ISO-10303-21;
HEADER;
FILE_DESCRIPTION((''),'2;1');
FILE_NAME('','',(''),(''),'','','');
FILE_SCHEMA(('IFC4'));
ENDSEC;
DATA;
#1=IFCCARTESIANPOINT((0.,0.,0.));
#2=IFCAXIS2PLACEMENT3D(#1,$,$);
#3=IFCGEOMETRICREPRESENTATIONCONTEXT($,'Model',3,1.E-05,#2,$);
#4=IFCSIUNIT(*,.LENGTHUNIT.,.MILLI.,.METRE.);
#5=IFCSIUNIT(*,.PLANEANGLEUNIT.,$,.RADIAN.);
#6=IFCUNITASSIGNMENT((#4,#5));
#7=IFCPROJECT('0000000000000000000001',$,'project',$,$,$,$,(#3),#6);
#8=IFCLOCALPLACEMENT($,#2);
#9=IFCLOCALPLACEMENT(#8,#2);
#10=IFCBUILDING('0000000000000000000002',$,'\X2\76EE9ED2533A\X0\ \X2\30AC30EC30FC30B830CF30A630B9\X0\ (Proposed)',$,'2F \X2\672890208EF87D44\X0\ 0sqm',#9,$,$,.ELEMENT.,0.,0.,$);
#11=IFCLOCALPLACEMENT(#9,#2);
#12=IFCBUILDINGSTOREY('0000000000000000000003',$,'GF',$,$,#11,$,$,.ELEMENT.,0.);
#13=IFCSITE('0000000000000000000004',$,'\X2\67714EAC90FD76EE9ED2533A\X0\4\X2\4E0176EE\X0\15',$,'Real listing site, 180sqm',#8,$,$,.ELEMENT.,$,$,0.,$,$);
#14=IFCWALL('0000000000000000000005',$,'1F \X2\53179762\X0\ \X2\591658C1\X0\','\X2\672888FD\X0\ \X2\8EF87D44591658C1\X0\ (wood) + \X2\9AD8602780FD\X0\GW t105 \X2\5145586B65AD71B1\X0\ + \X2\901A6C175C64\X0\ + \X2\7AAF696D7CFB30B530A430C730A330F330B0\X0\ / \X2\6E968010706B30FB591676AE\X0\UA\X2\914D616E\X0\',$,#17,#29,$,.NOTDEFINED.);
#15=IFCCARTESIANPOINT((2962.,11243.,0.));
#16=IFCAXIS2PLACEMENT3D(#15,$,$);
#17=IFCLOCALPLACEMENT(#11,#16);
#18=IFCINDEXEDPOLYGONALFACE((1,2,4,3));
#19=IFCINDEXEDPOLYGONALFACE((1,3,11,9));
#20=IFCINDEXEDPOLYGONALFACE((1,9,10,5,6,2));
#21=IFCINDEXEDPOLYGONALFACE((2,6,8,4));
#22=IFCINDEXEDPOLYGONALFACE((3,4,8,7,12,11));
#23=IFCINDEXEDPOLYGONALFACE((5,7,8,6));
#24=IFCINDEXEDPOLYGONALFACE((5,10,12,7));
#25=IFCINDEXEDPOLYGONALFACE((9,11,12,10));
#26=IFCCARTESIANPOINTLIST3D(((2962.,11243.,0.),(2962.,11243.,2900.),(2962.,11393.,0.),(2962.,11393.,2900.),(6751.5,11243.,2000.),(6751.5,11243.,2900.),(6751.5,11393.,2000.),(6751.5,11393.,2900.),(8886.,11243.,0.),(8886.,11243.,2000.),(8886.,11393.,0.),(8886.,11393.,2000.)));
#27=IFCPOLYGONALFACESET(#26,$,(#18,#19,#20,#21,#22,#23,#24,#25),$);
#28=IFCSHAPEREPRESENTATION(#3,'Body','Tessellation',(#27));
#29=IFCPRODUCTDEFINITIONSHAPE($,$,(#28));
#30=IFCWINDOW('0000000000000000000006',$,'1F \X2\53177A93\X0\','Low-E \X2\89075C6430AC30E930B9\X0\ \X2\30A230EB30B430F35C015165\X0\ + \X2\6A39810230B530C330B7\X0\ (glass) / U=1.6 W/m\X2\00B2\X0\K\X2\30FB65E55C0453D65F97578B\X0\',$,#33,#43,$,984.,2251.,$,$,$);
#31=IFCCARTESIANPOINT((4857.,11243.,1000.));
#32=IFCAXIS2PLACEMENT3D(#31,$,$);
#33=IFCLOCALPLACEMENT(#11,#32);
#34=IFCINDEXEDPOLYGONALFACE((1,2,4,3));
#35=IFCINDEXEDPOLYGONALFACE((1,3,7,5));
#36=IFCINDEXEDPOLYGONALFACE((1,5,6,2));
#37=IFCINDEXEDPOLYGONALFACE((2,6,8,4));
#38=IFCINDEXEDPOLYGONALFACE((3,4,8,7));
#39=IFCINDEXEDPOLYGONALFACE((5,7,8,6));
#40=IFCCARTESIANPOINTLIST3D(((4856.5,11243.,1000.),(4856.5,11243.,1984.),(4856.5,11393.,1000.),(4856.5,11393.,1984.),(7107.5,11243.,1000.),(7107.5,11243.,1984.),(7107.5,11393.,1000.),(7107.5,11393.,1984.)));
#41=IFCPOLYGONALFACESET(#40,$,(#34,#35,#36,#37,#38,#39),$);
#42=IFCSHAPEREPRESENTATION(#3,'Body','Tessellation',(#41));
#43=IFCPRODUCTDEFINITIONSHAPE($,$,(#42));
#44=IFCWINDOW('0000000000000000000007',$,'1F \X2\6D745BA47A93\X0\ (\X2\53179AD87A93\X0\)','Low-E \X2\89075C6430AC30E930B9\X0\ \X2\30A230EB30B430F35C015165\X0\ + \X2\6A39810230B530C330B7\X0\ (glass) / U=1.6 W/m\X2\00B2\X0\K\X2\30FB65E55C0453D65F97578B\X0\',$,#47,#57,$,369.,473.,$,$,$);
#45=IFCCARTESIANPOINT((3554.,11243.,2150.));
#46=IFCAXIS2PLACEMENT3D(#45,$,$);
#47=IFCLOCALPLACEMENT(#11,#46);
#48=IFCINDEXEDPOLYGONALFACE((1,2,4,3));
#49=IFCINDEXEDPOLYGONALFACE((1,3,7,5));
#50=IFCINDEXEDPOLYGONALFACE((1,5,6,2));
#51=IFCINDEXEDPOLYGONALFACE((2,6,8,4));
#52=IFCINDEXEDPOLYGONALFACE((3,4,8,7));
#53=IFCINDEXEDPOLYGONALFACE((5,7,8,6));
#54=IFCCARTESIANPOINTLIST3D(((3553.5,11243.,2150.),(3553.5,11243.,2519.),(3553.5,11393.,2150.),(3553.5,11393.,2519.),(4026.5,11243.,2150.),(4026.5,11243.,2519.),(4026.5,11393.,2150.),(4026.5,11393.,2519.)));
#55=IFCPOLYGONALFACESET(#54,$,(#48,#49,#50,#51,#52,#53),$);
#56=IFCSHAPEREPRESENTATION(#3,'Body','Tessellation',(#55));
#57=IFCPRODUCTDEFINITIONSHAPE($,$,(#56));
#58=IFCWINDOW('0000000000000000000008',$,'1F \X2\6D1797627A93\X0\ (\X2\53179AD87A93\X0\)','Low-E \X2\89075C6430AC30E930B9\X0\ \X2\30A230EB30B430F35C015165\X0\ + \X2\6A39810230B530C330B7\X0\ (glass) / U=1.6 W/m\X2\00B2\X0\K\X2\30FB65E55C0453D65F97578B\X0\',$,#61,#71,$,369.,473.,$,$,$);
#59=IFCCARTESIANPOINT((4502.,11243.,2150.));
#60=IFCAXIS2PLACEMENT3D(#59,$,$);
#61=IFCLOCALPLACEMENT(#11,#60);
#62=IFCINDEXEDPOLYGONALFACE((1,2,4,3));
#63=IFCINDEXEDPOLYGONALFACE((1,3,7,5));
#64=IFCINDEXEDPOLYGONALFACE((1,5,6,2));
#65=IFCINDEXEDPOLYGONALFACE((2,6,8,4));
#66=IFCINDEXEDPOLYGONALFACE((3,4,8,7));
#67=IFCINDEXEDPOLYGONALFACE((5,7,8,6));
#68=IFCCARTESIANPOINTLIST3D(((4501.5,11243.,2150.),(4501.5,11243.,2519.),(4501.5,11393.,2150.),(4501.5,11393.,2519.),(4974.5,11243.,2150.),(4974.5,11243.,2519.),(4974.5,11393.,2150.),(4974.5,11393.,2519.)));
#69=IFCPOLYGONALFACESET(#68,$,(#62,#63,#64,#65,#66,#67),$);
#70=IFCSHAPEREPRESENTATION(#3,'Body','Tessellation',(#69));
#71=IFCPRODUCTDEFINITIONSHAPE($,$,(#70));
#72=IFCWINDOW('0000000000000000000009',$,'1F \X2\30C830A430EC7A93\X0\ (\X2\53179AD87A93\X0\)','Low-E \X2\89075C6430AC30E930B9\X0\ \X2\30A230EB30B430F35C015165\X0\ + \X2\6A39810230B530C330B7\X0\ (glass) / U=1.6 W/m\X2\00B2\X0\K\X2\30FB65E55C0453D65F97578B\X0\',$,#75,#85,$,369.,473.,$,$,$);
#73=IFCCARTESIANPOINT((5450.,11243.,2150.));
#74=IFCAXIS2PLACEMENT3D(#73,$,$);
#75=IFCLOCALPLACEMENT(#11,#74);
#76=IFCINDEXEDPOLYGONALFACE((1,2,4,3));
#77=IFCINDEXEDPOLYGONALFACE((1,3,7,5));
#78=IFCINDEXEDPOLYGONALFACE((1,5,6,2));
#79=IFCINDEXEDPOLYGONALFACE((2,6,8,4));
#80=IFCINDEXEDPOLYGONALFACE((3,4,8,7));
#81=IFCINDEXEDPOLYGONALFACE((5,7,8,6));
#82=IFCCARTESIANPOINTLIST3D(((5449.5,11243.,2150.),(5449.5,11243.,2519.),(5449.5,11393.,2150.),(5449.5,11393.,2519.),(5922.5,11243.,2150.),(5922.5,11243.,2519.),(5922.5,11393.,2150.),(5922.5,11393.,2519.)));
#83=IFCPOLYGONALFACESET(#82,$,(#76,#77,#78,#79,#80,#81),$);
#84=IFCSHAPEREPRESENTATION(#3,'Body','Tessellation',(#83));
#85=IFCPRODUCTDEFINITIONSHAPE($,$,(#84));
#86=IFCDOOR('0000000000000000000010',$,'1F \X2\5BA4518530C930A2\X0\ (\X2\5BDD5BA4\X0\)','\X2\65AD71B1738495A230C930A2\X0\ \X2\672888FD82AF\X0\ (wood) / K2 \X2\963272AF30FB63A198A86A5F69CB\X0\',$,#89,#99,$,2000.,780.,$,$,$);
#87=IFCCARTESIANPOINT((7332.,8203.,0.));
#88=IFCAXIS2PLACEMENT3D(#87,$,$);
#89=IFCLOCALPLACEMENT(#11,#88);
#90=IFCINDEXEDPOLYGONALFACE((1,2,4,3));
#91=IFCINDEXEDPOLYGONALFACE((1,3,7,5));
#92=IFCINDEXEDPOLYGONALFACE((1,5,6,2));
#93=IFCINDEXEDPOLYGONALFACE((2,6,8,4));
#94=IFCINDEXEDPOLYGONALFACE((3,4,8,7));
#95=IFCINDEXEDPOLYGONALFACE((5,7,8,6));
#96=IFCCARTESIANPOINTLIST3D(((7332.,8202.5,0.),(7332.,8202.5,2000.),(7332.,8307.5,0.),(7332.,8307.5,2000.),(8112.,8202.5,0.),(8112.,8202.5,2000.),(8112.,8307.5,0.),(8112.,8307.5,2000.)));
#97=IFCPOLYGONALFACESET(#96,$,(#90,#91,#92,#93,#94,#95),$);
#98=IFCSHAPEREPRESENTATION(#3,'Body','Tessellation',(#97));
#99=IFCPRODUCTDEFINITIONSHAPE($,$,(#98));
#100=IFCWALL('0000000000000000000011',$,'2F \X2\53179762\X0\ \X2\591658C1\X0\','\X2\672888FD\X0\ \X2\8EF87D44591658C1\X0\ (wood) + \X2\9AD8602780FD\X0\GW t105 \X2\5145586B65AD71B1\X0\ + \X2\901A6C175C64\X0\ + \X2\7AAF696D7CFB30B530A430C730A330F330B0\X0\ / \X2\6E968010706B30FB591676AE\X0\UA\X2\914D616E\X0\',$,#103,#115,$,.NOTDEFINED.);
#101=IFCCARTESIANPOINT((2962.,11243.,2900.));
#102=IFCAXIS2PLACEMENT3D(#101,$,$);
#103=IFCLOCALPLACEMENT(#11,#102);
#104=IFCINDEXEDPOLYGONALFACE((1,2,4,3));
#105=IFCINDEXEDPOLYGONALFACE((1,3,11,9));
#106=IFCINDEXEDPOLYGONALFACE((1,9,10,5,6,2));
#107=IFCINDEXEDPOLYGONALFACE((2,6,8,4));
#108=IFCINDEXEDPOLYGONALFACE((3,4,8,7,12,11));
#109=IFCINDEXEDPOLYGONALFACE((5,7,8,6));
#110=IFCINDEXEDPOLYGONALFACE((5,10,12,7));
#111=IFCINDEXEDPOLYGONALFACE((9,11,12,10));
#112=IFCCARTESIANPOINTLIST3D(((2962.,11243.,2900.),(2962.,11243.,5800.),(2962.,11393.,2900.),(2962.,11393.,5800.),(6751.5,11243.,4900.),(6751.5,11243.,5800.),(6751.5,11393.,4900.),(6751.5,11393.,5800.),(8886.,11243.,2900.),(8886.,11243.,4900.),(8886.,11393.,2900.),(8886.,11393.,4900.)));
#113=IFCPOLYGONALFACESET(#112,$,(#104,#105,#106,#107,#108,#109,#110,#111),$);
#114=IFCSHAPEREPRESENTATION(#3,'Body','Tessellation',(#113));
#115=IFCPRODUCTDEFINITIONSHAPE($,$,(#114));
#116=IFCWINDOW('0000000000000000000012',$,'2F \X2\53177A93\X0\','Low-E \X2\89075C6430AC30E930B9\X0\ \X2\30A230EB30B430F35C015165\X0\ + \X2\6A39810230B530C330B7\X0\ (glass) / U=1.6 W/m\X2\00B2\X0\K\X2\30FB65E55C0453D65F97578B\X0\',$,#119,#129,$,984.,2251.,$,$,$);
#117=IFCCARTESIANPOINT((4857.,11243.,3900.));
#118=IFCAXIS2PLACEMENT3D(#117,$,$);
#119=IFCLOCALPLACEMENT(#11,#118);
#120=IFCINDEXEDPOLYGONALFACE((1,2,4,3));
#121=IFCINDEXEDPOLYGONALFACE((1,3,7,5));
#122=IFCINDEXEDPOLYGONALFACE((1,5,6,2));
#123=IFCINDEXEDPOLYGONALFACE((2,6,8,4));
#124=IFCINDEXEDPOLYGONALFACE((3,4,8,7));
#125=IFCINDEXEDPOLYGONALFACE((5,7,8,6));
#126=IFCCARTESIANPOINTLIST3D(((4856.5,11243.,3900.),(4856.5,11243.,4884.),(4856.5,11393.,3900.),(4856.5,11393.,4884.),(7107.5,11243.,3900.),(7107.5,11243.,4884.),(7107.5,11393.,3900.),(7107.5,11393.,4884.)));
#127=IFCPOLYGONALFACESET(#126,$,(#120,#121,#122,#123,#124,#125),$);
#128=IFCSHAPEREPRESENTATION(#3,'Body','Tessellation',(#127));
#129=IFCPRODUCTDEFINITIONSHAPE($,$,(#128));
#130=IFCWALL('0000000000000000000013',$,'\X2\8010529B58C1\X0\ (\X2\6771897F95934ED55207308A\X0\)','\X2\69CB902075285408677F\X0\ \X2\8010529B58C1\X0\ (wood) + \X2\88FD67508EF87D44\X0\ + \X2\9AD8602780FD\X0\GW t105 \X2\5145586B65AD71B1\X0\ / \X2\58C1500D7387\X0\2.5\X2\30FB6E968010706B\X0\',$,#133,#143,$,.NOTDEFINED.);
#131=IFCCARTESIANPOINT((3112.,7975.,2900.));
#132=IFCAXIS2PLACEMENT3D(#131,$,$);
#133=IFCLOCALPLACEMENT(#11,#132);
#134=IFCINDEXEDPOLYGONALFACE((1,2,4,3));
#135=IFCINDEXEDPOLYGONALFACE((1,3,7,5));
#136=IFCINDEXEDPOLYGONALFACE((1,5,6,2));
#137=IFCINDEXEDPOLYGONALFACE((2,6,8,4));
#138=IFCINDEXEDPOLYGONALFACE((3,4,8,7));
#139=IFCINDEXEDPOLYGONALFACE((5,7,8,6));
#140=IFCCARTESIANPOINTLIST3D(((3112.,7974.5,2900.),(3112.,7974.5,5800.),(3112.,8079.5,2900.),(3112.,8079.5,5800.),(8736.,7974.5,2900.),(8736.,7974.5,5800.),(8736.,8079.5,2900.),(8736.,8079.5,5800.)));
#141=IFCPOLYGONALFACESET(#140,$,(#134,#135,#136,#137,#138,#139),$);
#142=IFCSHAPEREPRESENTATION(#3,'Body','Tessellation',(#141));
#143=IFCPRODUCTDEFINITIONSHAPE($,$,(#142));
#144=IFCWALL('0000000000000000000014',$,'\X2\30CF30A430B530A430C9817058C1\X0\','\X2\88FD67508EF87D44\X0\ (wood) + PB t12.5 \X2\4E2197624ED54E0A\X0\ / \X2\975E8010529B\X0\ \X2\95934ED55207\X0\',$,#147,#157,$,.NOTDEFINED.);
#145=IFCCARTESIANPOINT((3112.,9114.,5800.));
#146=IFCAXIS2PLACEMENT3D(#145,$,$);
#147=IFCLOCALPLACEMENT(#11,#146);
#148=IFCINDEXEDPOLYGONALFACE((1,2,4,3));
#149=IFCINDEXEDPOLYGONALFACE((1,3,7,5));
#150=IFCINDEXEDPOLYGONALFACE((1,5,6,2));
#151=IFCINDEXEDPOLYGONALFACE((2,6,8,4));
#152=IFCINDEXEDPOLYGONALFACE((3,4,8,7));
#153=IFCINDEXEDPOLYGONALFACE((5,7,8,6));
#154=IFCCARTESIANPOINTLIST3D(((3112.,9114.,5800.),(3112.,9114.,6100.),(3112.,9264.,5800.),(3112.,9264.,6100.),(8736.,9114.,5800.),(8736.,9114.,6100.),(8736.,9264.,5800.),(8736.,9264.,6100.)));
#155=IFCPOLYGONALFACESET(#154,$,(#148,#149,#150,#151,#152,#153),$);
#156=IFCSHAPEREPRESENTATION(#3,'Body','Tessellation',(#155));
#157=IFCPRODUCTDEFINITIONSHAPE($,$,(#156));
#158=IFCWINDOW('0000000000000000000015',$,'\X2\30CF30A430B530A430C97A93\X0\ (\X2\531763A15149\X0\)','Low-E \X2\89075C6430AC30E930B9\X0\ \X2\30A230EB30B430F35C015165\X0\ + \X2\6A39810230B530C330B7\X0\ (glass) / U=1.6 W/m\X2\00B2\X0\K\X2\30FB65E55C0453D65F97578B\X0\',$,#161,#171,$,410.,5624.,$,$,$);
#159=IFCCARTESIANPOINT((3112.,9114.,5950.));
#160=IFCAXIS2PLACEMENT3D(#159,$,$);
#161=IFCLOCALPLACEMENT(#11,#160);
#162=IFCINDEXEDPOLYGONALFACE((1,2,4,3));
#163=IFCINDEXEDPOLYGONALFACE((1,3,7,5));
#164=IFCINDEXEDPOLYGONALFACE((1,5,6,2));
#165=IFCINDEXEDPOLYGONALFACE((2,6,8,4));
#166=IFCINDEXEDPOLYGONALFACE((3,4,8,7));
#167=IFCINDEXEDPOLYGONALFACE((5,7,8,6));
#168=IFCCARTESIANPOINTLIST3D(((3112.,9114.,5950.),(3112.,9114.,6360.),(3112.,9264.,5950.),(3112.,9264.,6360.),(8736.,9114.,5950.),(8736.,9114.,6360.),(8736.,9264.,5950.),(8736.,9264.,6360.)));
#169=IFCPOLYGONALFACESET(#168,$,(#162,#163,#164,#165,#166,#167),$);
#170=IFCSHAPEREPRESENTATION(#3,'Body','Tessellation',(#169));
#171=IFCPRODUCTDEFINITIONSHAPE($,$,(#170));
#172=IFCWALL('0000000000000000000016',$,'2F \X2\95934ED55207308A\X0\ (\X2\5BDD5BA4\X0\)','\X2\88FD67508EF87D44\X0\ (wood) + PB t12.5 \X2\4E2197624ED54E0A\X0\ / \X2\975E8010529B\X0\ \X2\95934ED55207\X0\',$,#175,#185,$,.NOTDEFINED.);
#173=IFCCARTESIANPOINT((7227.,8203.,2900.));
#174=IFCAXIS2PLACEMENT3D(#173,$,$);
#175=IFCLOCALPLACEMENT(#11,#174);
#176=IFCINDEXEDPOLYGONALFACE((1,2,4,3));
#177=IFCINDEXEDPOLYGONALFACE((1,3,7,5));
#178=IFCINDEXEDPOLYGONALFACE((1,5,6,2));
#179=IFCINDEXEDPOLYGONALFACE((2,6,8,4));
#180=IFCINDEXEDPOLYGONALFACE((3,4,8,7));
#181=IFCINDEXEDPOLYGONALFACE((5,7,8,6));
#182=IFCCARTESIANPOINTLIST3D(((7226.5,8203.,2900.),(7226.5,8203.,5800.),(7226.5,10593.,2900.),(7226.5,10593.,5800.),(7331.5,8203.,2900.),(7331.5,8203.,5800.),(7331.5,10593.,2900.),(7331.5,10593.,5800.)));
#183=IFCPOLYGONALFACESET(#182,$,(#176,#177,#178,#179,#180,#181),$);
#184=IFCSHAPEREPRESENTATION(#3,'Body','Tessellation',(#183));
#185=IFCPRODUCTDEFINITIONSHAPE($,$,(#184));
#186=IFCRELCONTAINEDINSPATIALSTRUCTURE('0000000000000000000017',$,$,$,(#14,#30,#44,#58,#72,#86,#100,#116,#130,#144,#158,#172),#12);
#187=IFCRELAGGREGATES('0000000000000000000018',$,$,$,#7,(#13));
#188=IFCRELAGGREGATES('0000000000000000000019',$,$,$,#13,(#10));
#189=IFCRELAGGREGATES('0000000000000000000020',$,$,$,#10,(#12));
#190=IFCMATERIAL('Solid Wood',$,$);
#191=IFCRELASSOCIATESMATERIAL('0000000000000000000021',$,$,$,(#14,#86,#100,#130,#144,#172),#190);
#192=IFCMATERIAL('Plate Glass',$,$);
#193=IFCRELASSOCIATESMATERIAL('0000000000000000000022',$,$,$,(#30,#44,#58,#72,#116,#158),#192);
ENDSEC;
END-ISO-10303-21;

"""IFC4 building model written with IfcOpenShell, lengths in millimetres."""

from ifc_helpers import new_model, si_unit, frame, frame_2d, origin, place, context, project, spatial, rectangle, extrude, material, element, fill, save


model = new_model("IFC4")

# Units and contexts
model_context = context("Model", 3, precision=1e-05, world=origin())
ifc_project = project(units=[si_unit("LENGTHUNIT", "METRE", prefix="MILLI"), si_unit("PLANEANGLEUNIT", "RADIAN")], contexts=[model_context])

# Site, building, storey
site_placement = place(None, origin())
site = spatial("IfcSite", under=ifc_project, at=site_placement, Name="東京都目黒区4丁目15", ObjectType="Real listing site, 180sqm", CompositionType="ELEMENT", RefElevation=0.0)
building_placement = place(site_placement, origin())
building = spatial("IfcBuilding", under=site, at=building_placement, Name="目黒区 ガレージハウス (Proposed)", ObjectType="2F 木造軸組 0sqm", CompositionType="ELEMENT", ElevationOfRefHeight=0.0, ElevationOfTerrain=0.0)
storey_placement = place(building_placement, origin())
storey = spatial("IfcBuildingStorey", under=building, at=storey_placement, Name="GF", CompositionType="ELEMENT", Elevation=0.0)

# Wall, openings, windows
ifc_material_1 = material(Name="Solid Wood")
wall_1_placement = place(storey_placement, frame((2962.0, 11243.0, 0.0)))
wall_1 = element("IfcWall", 1, at=wall_1_placement, inside=storey, material=ifc_material_1, Name="1F 北面 外壁", Description="木製 軸組外壁 (wood) + 高性能GW t105 充填断熱 + 通気層 + 窯業系サイディング / 準耐火・外皮UA配慮", PredefinedType="NOTDEFINED", context=model_context, shape_type="SweptSolid", body=[
    extrude(rectangle(XDim=5924.0, YDim=150.0, at=frame_2d((2962.0, 75.0))), frame((2962.0, 11243.0, 0.0)), (0.0, 0.0, 1.0), 2900.0),
])
opening_1_placement = place(storey_placement, frame((4857.0, 11243.0, 1000.0)))
opening_1 = element("IfcOpeningElement", 2, at=opening_1_placement, cuts=wall_1, PredefinedType="NOTDEFINED", context=model_context, shape_type="SweptSolid", body=[
    extrude(rectangle(XDim=2251.0, YDim=150.0, at=frame_2d((1125.0, 75.0))), frame((4857.0, 11243.0, 1000.0)), (0.0, 0.0, 1.0), 984.0),
])
opening_2_placement = place(storey_placement, frame((3554.0, 11243.0, 2150.0)))
opening_2 = element("IfcOpeningElement", 3, at=opening_2_placement, cuts=wall_1, PredefinedType="NOTDEFINED", context=model_context, shape_type="SweptSolid", body=[
    extrude(rectangle(XDim=473.0, YDim=150.0, at=frame_2d((236.0, 75.0))), frame((3554.0, 11243.0, 2150.0)), (0.0, 0.0, 1.0), 369.0),
])
opening_3_placement = place(storey_placement, frame((4502.0, 11243.0, 2150.0)))
opening_3 = element("IfcOpeningElement", 4, at=opening_3_placement, cuts=wall_1, PredefinedType="NOTDEFINED", context=model_context, shape_type="SweptSolid", body=[
    extrude(rectangle(XDim=473.0, YDim=150.0, at=frame_2d((236.0, 75.0))), frame((4502.0, 11243.0, 2150.0)), (0.0, 0.0, 1.0), 369.0),
])
opening_4_placement = place(storey_placement, frame((5450.0, 11243.0, 2150.0)))
opening_4 = element("IfcOpeningElement", 5, at=opening_4_placement, cuts=wall_1, PredefinedType="NOTDEFINED", context=model_context, shape_type="SweptSolid", body=[
    extrude(rectangle(XDim=473.0, YDim=150.0, at=frame_2d((236.0, 75.0))), frame((5450.0, 11243.0, 2150.0)), (0.0, 0.0, 1.0), 369.0),
])
ifc_material_2 = material(Name="Plate Glass")
window_1_placement = place(storey_placement, frame((4857.0, 11243.0, 1000.0)))
window_1 = element("IfcWindow", 6, at=window_1_placement, inside=storey, material=ifc_material_2, Name="1F 北窓", Description="Low-E 複層ガラス アルゴン封入 + 樹脂サッシ (glass) / U=1.6 W/m²K・日射取得型", OverallHeight=984.0, OverallWidth=2251.0, context=model_context, shape_type="SweptSolid", body=[
    extrude(rectangle(XDim=2251.0, YDim=150.0, at=frame_2d((1125.0, 75.0))), frame((4857.0, 11243.0, 1000.0)), (0.0, 0.0, 1.0), 984.0),
])
fill(opening_1, window_1)
window_2_placement = place(storey_placement, frame((3554.0, 11243.0, 2150.0)))
window_2 = element("IfcWindow", 7, at=window_2_placement, inside=storey, material=ifc_material_2, Name="1F 浴室窓 (北高窓)", Description="Low-E 複層ガラス アルゴン封入 + 樹脂サッシ (glass) / U=1.6 W/m²K・日射取得型", OverallHeight=369.0, OverallWidth=473.0, context=model_context, shape_type="SweptSolid", body=[
    extrude(rectangle(XDim=473.0, YDim=150.0, at=frame_2d((236.0, 75.0))), frame((3554.0, 11243.0, 2150.0)), (0.0, 0.0, 1.0), 369.0),
])
fill(opening_2, window_2)
window_3_placement = place(storey_placement, frame((4502.0, 11243.0, 2150.0)))
window_3 = element("IfcWindow", 8, at=window_3_placement, inside=storey, material=ifc_material_2, Name="1F 洗面窓 (北高窓)", Description="Low-E 複層ガラス アルゴン封入 + 樹脂サッシ (glass) / U=1.6 W/m²K・日射取得型", OverallHeight=369.0, OverallWidth=473.0, context=model_context, shape_type="SweptSolid", body=[
    extrude(rectangle(XDim=473.0, YDim=150.0, at=frame_2d((236.0, 75.0))), frame((4502.0, 11243.0, 2150.0)), (0.0, 0.0, 1.0), 369.0),
])
fill(opening_3, window_3)
window_4_placement = place(storey_placement, frame((5450.0, 11243.0, 2150.0)))
window_4 = element("IfcWindow", 9, at=window_4_placement, inside=storey, material=ifc_material_2, Name="1F トイレ窓 (北高窓)", Description="Low-E 複層ガラス アルゴン封入 + 樹脂サッシ (glass) / U=1.6 W/m²K・日射取得型", OverallHeight=369.0, OverallWidth=473.0, context=model_context, shape_type="SweptSolid", body=[
    extrude(rectangle(XDim=473.0, YDim=150.0, at=frame_2d((236.0, 75.0))), frame((5450.0, 11243.0, 2150.0)), (0.0, 0.0, 1.0), 369.0),
])
fill(opening_4, window_4)

# Door
door_1_placement = place(storey_placement, frame((7332.0, 8203.0, 0.0)))
element("IfcDoor", 10, at=door_1_placement, inside=storey, material=ifc_material_1, Name="1F 室内ドア (寝室)", Description="断熱玄関ドア 木製芯 (wood) / K2 防犯・採風機構", OverallHeight=2000.0, OverallWidth=780.0, context=model_context, shape_type="SweptSolid", body=[
    extrude(rectangle(XDim=780.0, YDim=105.0, at=frame_2d((390.0, 52.0))), frame((7332.0, 8203.0, 0.0)), (0.0, 0.0, 1.0), 2000.0),
])

# Wall, opening, window
wall_2_placement = place(storey_placement, frame((2962.0, 11243.0, 2900.0)))
wall_2 = element("IfcWall", 11, at=wall_2_placement, inside=storey, material=ifc_material_1, Name="2F 北面 外壁", Description="木製 軸組外壁 (wood) + 高性能GW t105 充填断熱 + 通気層 + 窯業系サイディング / 準耐火・外皮UA配慮", PredefinedType="NOTDEFINED", context=model_context, shape_type="SweptSolid", body=[
    extrude(rectangle(XDim=5924.0, YDim=150.0, at=frame_2d((2962.0, 75.0))), frame((2962.0, 11243.0, 2900.0)), (0.0, 0.0, 1.0), 2900.0),
])
opening_5_placement = place(storey_placement, frame((4857.0, 11243.0, 3900.0)))
opening_5 = element("IfcOpeningElement", 12, at=opening_5_placement, cuts=wall_2, PredefinedType="NOTDEFINED", context=model_context, shape_type="SweptSolid", body=[
    extrude(rectangle(XDim=2251.0, YDim=150.0, at=frame_2d((1125.0, 75.0))), frame((4857.0, 11243.0, 3900.0)), (0.0, 0.0, 1.0), 984.0),
])
window_5_placement = place(storey_placement, frame((4857.0, 11243.0, 3900.0)))
window_5 = element("IfcWindow", 13, at=window_5_placement, inside=storey, material=ifc_material_2, Name="2F 北窓", Description="Low-E 複層ガラス アルゴン封入 + 樹脂サッシ (glass) / U=1.6 W/m²K・日射取得型", OverallHeight=984.0, OverallWidth=2251.0, context=model_context, shape_type="SweptSolid", body=[
    extrude(rectangle(XDim=2251.0, YDim=150.0, at=frame_2d((1125.0, 75.0))), frame((4857.0, 11243.0, 3900.0)), (0.0, 0.0, 1.0), 984.0),
])
fill(opening_5, window_5)

# Wall
wall_3_placement = place(storey_placement, frame((3112.0, 7975.0, 2900.0)))
element("IfcWall", 14, at=wall_3_placement, inside=storey, material=ifc_material_1, Name="耐力壁 (東西間仕切り)", Description="構造用合板 耐力壁 (wood) + 製材軸組 + 高性能GW t105 充填断熱 / 壁倍率2.5・準耐火", PredefinedType="NOTDEFINED", context=model_context, shape_type="SweptSolid", body=[
    extrude(rectangle(XDim=5624.0, YDim=105.0, at=frame_2d((2812.0, 52.0))), frame((3112.0, 7975.0, 2900.0)), (0.0, 0.0, 1.0), 2900.0),
])

# Wall, opening, window
wall_4_placement = place(storey_placement, frame((3112.0, 9114.0, 5800.0)))
wall_4 = element("IfcWall", 15, at=wall_4_placement, inside=storey, material=ifc_material_1, Name="ハイサイド腰壁", Description="製材軸組 (wood) + PB t12.5 両面仕上 / 非耐力 間仕切", PredefinedType="NOTDEFINED", context=model_context, shape_type="SweptSolid", body=[
    extrude(rectangle(XDim=5624.0, YDim=150.0, at=frame_2d((2812.0, 75.0))), frame((3112.0, 9114.0, 5800.0)), (0.0, 0.0, 1.0), 700.0),
])
opening_6_placement = place(storey_placement, frame((3112.0, 9114.0, 5950.0)))
opening_6 = element("IfcOpeningElement", 16, at=opening_6_placement, cuts=wall_4, PredefinedType="NOTDEFINED", context=model_context, shape_type="SweptSolid", body=[
    extrude(rectangle(XDim=5624.0, YDim=150.0, at=frame_2d((2812.0, 75.0))), frame((3112.0, 9114.0, 5950.0)), (0.0, 0.0, 1.0), 410.0),
])
window_6_placement = place(storey_placement, frame((3112.0, 9114.0, 5950.0)))
window_6 = element("IfcWindow", 17, at=window_6_placement, inside=storey, material=ifc_material_2, Name="ハイサイド窓 (北採光)", Description="Low-E 複層ガラス アルゴン封入 + 樹脂サッシ (glass) / U=1.6 W/m²K・日射取得型", OverallHeight=410.0, OverallWidth=5624.0, context=model_context, shape_type="SweptSolid", body=[
    extrude(rectangle(XDim=5624.0, YDim=150.0, at=frame_2d((2812.0, 75.0))), frame((3112.0, 9114.0, 5950.0)), (0.0, 0.0, 1.0), 410.0),
])
fill(opening_6, window_6)

# Wall
wall_5_placement = place(storey_placement, frame((7227.0, 8203.0, 2900.0)))
element("IfcWall", 18, at=wall_5_placement, inside=storey, material=ifc_material_1, Name="2F 間仕切り (寝室)", Description="製材軸組 (wood) + PB t12.5 両面仕上 / 非耐力 間仕切", PredefinedType="NOTDEFINED", context=model_context, shape_type="SweptSolid", body=[
    extrude(rectangle(XDim=105.0, YDim=2390.0, at=frame_2d((52.0, 1195.0))), frame((7227.0, 8203.0, 2900.0)), (0.0, 0.0, 1.0), 2900.0),
])

save(model, "model.ifc")
